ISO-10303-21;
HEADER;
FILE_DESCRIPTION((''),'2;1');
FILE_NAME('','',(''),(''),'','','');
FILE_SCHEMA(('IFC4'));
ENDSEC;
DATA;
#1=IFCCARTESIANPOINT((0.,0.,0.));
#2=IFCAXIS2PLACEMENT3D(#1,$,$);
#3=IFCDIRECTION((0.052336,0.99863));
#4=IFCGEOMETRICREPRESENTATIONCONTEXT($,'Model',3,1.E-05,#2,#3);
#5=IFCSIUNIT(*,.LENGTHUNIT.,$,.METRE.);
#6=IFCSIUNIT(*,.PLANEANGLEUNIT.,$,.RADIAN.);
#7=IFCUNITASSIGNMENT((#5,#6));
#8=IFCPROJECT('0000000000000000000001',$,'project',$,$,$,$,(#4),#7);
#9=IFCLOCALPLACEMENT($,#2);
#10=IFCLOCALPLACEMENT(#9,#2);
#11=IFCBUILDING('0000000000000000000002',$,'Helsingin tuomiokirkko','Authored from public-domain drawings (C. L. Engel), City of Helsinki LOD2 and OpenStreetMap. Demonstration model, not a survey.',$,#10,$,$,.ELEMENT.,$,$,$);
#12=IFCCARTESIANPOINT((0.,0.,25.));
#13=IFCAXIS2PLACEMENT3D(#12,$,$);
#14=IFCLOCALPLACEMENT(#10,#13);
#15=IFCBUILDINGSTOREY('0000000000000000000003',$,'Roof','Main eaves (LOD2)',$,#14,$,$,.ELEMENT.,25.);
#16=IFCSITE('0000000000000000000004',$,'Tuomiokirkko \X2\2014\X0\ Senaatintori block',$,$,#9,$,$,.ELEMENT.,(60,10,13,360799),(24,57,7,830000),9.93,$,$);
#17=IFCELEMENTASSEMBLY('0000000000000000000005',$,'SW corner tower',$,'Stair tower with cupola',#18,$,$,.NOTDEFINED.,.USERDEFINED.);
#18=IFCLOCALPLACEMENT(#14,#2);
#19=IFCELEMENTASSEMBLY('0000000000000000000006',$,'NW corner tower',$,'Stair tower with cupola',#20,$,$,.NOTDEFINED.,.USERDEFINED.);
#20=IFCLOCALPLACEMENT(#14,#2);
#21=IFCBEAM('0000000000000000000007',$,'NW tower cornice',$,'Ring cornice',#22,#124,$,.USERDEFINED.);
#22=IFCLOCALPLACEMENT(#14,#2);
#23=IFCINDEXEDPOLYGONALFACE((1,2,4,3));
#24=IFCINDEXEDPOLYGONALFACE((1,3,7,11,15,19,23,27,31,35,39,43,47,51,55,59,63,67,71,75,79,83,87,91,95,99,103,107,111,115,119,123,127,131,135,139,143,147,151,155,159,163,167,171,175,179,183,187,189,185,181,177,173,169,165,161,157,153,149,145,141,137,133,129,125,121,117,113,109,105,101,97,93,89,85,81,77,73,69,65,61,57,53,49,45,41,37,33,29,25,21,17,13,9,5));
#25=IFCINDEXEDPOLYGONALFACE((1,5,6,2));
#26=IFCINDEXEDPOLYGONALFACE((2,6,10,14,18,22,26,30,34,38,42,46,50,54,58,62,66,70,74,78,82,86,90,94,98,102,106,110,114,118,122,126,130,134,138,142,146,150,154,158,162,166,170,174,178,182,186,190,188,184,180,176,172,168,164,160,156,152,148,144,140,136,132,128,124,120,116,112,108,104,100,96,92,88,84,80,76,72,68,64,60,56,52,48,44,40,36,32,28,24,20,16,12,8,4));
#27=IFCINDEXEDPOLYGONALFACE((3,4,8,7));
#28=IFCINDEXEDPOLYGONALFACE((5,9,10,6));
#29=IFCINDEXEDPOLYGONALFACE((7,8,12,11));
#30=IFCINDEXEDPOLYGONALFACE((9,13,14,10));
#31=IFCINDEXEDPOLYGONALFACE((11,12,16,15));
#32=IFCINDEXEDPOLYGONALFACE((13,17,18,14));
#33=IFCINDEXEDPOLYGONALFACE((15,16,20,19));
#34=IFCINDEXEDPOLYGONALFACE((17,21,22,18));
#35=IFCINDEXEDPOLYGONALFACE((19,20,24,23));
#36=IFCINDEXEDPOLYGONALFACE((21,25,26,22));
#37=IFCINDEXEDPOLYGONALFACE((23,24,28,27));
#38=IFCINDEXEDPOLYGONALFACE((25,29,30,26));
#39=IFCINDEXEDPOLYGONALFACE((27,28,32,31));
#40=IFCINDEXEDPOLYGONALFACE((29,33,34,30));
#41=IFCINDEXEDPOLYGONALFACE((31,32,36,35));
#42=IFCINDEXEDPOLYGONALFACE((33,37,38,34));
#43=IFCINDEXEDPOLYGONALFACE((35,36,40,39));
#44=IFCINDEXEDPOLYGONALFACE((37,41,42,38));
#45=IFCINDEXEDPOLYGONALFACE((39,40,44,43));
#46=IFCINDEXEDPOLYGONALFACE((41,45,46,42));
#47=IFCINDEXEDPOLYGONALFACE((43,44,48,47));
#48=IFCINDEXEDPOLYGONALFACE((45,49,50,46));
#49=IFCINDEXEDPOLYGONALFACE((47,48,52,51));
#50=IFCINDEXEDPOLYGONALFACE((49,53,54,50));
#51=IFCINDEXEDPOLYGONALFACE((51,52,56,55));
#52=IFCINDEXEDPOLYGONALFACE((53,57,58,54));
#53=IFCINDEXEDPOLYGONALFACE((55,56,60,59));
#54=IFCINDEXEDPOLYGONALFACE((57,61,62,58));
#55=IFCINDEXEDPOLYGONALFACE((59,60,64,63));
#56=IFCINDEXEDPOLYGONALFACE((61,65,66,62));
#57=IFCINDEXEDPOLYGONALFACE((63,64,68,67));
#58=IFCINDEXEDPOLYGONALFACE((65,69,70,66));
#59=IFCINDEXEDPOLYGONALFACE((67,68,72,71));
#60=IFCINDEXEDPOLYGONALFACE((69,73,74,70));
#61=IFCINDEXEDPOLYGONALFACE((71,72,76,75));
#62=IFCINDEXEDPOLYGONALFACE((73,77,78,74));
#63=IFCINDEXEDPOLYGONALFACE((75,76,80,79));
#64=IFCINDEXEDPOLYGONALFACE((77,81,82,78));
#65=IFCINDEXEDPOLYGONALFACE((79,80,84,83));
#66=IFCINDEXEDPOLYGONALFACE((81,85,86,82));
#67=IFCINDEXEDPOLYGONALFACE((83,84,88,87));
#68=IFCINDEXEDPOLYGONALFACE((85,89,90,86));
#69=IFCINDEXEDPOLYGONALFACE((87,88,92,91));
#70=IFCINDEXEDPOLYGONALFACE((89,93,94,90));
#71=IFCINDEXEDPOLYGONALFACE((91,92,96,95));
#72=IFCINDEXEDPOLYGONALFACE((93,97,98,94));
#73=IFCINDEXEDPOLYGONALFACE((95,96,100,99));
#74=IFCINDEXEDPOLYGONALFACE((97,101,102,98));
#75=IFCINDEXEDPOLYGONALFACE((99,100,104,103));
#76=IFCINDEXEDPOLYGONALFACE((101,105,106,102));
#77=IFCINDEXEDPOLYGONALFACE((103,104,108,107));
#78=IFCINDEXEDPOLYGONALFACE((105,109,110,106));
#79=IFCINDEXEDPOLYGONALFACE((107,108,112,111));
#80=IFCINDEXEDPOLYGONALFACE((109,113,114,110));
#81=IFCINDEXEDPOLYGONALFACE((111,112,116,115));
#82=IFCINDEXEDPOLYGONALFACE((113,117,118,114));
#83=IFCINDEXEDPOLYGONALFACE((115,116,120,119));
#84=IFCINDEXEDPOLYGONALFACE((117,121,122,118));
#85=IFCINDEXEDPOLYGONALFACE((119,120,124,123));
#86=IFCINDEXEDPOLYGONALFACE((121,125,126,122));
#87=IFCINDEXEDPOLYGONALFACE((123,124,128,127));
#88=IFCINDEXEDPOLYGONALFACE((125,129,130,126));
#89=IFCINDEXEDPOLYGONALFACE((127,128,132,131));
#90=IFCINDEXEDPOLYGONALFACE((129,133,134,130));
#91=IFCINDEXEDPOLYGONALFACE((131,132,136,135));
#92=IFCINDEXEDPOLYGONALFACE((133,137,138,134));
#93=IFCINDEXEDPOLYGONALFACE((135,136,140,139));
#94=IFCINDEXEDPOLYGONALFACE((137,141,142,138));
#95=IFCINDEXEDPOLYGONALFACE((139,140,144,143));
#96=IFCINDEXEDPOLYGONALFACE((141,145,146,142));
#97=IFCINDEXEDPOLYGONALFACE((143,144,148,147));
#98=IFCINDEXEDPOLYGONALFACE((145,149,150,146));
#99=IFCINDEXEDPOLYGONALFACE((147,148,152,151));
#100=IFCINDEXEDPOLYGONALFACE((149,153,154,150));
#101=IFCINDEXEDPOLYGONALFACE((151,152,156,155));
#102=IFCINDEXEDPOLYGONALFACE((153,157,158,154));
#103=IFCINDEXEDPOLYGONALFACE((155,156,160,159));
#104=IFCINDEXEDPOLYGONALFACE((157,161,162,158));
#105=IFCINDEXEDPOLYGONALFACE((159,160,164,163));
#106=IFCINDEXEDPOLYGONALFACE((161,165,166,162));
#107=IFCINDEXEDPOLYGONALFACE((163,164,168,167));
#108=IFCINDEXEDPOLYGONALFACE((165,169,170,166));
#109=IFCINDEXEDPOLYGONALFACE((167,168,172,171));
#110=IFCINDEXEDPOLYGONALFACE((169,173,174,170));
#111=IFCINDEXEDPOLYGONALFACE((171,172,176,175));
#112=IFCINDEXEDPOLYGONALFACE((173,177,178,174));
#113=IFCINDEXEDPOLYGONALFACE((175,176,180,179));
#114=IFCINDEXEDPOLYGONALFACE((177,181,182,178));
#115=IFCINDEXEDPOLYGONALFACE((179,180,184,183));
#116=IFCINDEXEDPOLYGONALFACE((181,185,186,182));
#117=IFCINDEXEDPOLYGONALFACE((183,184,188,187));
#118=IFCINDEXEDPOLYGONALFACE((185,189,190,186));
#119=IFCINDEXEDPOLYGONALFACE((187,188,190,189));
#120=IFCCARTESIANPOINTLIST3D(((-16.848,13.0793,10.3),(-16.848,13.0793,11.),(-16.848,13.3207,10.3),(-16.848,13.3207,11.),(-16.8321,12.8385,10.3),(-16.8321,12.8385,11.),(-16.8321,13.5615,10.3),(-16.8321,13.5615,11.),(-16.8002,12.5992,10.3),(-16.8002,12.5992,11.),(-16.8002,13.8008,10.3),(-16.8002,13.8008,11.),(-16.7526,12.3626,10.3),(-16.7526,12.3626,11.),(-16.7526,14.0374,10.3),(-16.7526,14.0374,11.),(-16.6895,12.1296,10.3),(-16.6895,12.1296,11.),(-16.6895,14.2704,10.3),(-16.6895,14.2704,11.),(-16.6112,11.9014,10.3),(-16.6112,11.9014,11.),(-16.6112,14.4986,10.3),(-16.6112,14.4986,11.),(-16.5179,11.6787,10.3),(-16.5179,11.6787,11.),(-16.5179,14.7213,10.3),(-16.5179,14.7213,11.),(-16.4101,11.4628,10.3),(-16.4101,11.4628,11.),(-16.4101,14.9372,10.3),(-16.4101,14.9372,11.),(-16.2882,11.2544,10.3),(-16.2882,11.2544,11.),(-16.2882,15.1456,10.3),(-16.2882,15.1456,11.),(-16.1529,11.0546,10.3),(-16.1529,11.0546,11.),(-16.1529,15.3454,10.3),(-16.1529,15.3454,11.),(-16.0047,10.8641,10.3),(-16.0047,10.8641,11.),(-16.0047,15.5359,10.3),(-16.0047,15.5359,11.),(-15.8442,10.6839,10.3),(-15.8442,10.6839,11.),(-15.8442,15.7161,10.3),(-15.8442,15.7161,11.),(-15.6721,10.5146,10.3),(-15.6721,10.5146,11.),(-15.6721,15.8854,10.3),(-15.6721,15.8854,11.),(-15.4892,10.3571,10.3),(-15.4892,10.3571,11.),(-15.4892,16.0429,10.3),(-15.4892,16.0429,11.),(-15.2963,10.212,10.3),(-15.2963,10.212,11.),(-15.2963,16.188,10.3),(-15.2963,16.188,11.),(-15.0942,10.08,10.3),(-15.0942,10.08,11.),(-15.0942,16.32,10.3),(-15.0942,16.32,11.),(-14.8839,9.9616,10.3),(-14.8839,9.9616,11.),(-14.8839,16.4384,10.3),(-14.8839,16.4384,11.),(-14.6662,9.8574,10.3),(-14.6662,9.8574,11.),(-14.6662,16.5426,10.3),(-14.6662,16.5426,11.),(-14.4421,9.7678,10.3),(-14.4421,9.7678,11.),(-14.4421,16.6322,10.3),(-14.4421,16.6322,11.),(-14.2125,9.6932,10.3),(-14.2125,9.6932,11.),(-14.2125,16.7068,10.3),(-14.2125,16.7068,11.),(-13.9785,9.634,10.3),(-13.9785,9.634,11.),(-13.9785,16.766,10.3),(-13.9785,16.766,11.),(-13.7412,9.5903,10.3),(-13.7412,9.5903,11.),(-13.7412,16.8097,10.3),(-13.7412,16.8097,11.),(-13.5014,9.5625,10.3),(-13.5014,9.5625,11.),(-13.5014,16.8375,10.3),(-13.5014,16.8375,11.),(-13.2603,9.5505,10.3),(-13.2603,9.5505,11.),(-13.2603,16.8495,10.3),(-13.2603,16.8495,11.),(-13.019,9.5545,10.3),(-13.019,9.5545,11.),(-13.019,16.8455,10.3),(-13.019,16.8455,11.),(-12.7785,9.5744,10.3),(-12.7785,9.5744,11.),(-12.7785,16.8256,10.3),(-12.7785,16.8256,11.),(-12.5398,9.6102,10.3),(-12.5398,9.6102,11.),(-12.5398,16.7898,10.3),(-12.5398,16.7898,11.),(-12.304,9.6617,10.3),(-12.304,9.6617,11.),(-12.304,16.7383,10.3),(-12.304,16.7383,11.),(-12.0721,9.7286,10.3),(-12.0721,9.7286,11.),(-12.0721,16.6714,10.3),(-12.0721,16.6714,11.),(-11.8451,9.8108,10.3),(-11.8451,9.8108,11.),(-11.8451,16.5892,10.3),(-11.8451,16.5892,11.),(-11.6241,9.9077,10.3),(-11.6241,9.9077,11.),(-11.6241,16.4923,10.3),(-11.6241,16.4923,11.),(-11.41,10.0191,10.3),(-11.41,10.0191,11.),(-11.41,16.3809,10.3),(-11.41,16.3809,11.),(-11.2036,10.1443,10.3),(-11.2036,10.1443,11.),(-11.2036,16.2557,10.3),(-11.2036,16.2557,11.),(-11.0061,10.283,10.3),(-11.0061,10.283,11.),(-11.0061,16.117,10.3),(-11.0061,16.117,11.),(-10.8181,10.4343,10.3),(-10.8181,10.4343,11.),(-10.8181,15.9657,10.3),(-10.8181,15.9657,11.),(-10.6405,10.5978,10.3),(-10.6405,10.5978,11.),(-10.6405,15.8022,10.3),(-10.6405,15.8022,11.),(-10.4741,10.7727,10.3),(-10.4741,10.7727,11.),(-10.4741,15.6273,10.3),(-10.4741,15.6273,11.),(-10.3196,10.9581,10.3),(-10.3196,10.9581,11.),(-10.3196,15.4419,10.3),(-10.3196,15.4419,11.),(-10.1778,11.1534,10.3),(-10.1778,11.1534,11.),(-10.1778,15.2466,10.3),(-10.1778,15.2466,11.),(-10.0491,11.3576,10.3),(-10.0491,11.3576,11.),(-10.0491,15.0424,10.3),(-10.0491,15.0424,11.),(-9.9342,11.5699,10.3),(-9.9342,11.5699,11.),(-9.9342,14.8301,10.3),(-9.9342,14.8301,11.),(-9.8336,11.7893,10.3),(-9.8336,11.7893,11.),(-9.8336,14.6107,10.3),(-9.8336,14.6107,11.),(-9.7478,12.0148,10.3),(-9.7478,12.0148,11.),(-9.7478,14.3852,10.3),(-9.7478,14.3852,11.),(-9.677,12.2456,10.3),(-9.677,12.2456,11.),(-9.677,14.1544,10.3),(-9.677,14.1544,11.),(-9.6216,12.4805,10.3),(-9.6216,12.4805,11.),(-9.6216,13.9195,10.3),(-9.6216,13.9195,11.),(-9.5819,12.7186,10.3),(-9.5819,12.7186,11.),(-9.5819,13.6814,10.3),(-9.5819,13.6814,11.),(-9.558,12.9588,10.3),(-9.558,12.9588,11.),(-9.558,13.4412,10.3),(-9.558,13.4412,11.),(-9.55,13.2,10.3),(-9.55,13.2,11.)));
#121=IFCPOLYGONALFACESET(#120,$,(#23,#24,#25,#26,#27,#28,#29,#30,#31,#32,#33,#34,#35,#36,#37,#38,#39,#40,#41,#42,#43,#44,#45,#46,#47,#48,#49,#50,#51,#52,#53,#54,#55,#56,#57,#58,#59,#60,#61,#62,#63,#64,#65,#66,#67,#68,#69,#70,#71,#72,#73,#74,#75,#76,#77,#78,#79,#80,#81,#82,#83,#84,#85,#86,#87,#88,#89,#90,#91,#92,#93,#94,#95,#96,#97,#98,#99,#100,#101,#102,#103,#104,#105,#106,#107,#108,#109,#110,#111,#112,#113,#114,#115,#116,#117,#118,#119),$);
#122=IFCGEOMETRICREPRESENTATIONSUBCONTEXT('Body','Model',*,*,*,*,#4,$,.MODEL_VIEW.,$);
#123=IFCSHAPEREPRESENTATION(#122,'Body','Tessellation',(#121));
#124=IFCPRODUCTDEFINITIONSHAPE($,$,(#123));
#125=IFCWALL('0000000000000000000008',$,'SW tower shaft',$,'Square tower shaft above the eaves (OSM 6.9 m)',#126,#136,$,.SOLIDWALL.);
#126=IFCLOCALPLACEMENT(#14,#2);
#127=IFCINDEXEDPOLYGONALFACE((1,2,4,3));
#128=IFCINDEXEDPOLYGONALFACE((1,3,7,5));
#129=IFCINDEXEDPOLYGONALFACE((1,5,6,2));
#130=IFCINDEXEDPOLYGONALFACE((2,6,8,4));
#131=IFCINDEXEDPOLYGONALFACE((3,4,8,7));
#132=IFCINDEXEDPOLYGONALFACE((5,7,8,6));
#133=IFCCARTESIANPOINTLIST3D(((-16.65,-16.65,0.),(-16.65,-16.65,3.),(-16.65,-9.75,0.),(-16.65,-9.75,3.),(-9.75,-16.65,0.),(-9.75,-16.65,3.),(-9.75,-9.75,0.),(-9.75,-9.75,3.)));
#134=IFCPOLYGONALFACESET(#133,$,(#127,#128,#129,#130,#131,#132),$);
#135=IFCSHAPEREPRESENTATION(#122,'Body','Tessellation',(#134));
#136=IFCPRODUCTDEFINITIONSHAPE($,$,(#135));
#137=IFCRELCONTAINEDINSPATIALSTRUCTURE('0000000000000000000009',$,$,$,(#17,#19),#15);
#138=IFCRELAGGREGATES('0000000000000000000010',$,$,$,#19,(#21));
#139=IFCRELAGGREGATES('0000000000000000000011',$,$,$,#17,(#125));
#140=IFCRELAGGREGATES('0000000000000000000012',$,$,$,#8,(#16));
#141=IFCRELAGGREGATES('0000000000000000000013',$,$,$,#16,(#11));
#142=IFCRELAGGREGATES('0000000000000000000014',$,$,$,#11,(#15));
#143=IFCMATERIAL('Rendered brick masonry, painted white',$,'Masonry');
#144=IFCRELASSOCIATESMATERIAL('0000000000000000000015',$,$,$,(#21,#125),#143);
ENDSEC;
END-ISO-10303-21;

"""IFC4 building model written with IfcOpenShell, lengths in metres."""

from ifc_helpers import new_model, si_unit, direction, frame, origin, origin_2d_with_axis, place, context, subcontext, project, spatial, rectangle, circle, extrude, material, element, aggregate, save


model = new_model("IFC4")

# Units and contexts
model_context = context("Model", 3, precision=1e-05, world=origin(), true_north=direction((0.052336, 0.99863)))
body_context = subcontext(model_context, "Body", "Model", "MODEL_VIEW")
ifc_project = project(units=[si_unit("LENGTHUNIT", "METRE"), si_unit("PLANEANGLEUNIT", "RADIAN")], contexts=[model_context])

# Site, building, storey
site_placement = place(None, origin())
site = spatial("IfcSite", under=ifc_project, at=site_placement, Name="Tuomiokirkko — Senaatintori block", CompositionType="ELEMENT", RefLatitude=(60, 10, 13, 360799), RefLongitude=(24, 57, 7, 830000), RefElevation=9.93)
building_placement = place(site_placement, origin())
building = spatial("IfcBuilding", under=site, at=building_placement, Name="Helsingin tuomiokirkko", Description="Authored from public-domain drawings (C. L. Engel), City of Helsinki LOD2 and OpenStreetMap. Demonstration model, not a survey.", CompositionType="ELEMENT")
storey_placement = place(building_placement, frame((0.0, 0.0, 25.0)))
storey = spatial("IfcBuildingStorey", under=building, at=storey_placement, Name="Roof", Description="Main eaves (LOD2)", CompositionType="ELEMENT", Elevation=25.0)

# Element assemblies
assembly_1_placement = place(building_placement, origin())
assembly_1 = element("IfcElementAssembly", 1, at=assembly_1_placement, inside=storey, Name="SW corner tower", ObjectType="Stair tower with cupola", AssemblyPlace="NOTDEFINED", PredefinedType="USERDEFINED")
assembly_2_placement = place(building_placement, origin())
assembly_2 = element("IfcElementAssembly", 2, at=assembly_2_placement, inside=storey, Name="NW corner tower", ObjectType="Stair tower with cupola", AssemblyPlace="NOTDEFINED", PredefinedType="USERDEFINED")

# Shared definitions
ifc_material_1 = material(Name="Rendered brick masonry, painted white", Category="Masonry")

# Beam
beam_1_placement = place(building_placement, origin())
beam_1 = element("IfcBeam", 3, at=beam_1_placement, material=ifc_material_1, Name="NW tower cornice", ObjectType="Ring cornice", PredefinedType="USERDEFINED", context=body_context, shape_type="SweptSolid", body=[
    extrude(circle(Radius=3.65, at=origin_2d_with_axis()), frame((-13.2, 13.2, 35.3)), (0.0, 0.0, 1.0), 0.7),
])

# Wall
wall_1_placement = place(building_placement, origin())
wall_1 = element("IfcWall", 4, at=wall_1_placement, material=ifc_material_1, Name="SW tower shaft", ObjectType="Square tower shaft above the eaves (OSM 6.9 m)", PredefinedType="SOLIDWALL", context=body_context, shape_type="SweptSolid", body=[
    extrude(rectangle(XDim=6.9, YDim=6.9, at=origin_2d_with_axis()), frame((-13.2, -13.2, 25.0)), (0.0, 0.0, 1.0), 3.0),
])
aggregate(assembly_2, [beam_1])

aggregate(assembly_1, [wall_1])

save(model, "model.ifc")
